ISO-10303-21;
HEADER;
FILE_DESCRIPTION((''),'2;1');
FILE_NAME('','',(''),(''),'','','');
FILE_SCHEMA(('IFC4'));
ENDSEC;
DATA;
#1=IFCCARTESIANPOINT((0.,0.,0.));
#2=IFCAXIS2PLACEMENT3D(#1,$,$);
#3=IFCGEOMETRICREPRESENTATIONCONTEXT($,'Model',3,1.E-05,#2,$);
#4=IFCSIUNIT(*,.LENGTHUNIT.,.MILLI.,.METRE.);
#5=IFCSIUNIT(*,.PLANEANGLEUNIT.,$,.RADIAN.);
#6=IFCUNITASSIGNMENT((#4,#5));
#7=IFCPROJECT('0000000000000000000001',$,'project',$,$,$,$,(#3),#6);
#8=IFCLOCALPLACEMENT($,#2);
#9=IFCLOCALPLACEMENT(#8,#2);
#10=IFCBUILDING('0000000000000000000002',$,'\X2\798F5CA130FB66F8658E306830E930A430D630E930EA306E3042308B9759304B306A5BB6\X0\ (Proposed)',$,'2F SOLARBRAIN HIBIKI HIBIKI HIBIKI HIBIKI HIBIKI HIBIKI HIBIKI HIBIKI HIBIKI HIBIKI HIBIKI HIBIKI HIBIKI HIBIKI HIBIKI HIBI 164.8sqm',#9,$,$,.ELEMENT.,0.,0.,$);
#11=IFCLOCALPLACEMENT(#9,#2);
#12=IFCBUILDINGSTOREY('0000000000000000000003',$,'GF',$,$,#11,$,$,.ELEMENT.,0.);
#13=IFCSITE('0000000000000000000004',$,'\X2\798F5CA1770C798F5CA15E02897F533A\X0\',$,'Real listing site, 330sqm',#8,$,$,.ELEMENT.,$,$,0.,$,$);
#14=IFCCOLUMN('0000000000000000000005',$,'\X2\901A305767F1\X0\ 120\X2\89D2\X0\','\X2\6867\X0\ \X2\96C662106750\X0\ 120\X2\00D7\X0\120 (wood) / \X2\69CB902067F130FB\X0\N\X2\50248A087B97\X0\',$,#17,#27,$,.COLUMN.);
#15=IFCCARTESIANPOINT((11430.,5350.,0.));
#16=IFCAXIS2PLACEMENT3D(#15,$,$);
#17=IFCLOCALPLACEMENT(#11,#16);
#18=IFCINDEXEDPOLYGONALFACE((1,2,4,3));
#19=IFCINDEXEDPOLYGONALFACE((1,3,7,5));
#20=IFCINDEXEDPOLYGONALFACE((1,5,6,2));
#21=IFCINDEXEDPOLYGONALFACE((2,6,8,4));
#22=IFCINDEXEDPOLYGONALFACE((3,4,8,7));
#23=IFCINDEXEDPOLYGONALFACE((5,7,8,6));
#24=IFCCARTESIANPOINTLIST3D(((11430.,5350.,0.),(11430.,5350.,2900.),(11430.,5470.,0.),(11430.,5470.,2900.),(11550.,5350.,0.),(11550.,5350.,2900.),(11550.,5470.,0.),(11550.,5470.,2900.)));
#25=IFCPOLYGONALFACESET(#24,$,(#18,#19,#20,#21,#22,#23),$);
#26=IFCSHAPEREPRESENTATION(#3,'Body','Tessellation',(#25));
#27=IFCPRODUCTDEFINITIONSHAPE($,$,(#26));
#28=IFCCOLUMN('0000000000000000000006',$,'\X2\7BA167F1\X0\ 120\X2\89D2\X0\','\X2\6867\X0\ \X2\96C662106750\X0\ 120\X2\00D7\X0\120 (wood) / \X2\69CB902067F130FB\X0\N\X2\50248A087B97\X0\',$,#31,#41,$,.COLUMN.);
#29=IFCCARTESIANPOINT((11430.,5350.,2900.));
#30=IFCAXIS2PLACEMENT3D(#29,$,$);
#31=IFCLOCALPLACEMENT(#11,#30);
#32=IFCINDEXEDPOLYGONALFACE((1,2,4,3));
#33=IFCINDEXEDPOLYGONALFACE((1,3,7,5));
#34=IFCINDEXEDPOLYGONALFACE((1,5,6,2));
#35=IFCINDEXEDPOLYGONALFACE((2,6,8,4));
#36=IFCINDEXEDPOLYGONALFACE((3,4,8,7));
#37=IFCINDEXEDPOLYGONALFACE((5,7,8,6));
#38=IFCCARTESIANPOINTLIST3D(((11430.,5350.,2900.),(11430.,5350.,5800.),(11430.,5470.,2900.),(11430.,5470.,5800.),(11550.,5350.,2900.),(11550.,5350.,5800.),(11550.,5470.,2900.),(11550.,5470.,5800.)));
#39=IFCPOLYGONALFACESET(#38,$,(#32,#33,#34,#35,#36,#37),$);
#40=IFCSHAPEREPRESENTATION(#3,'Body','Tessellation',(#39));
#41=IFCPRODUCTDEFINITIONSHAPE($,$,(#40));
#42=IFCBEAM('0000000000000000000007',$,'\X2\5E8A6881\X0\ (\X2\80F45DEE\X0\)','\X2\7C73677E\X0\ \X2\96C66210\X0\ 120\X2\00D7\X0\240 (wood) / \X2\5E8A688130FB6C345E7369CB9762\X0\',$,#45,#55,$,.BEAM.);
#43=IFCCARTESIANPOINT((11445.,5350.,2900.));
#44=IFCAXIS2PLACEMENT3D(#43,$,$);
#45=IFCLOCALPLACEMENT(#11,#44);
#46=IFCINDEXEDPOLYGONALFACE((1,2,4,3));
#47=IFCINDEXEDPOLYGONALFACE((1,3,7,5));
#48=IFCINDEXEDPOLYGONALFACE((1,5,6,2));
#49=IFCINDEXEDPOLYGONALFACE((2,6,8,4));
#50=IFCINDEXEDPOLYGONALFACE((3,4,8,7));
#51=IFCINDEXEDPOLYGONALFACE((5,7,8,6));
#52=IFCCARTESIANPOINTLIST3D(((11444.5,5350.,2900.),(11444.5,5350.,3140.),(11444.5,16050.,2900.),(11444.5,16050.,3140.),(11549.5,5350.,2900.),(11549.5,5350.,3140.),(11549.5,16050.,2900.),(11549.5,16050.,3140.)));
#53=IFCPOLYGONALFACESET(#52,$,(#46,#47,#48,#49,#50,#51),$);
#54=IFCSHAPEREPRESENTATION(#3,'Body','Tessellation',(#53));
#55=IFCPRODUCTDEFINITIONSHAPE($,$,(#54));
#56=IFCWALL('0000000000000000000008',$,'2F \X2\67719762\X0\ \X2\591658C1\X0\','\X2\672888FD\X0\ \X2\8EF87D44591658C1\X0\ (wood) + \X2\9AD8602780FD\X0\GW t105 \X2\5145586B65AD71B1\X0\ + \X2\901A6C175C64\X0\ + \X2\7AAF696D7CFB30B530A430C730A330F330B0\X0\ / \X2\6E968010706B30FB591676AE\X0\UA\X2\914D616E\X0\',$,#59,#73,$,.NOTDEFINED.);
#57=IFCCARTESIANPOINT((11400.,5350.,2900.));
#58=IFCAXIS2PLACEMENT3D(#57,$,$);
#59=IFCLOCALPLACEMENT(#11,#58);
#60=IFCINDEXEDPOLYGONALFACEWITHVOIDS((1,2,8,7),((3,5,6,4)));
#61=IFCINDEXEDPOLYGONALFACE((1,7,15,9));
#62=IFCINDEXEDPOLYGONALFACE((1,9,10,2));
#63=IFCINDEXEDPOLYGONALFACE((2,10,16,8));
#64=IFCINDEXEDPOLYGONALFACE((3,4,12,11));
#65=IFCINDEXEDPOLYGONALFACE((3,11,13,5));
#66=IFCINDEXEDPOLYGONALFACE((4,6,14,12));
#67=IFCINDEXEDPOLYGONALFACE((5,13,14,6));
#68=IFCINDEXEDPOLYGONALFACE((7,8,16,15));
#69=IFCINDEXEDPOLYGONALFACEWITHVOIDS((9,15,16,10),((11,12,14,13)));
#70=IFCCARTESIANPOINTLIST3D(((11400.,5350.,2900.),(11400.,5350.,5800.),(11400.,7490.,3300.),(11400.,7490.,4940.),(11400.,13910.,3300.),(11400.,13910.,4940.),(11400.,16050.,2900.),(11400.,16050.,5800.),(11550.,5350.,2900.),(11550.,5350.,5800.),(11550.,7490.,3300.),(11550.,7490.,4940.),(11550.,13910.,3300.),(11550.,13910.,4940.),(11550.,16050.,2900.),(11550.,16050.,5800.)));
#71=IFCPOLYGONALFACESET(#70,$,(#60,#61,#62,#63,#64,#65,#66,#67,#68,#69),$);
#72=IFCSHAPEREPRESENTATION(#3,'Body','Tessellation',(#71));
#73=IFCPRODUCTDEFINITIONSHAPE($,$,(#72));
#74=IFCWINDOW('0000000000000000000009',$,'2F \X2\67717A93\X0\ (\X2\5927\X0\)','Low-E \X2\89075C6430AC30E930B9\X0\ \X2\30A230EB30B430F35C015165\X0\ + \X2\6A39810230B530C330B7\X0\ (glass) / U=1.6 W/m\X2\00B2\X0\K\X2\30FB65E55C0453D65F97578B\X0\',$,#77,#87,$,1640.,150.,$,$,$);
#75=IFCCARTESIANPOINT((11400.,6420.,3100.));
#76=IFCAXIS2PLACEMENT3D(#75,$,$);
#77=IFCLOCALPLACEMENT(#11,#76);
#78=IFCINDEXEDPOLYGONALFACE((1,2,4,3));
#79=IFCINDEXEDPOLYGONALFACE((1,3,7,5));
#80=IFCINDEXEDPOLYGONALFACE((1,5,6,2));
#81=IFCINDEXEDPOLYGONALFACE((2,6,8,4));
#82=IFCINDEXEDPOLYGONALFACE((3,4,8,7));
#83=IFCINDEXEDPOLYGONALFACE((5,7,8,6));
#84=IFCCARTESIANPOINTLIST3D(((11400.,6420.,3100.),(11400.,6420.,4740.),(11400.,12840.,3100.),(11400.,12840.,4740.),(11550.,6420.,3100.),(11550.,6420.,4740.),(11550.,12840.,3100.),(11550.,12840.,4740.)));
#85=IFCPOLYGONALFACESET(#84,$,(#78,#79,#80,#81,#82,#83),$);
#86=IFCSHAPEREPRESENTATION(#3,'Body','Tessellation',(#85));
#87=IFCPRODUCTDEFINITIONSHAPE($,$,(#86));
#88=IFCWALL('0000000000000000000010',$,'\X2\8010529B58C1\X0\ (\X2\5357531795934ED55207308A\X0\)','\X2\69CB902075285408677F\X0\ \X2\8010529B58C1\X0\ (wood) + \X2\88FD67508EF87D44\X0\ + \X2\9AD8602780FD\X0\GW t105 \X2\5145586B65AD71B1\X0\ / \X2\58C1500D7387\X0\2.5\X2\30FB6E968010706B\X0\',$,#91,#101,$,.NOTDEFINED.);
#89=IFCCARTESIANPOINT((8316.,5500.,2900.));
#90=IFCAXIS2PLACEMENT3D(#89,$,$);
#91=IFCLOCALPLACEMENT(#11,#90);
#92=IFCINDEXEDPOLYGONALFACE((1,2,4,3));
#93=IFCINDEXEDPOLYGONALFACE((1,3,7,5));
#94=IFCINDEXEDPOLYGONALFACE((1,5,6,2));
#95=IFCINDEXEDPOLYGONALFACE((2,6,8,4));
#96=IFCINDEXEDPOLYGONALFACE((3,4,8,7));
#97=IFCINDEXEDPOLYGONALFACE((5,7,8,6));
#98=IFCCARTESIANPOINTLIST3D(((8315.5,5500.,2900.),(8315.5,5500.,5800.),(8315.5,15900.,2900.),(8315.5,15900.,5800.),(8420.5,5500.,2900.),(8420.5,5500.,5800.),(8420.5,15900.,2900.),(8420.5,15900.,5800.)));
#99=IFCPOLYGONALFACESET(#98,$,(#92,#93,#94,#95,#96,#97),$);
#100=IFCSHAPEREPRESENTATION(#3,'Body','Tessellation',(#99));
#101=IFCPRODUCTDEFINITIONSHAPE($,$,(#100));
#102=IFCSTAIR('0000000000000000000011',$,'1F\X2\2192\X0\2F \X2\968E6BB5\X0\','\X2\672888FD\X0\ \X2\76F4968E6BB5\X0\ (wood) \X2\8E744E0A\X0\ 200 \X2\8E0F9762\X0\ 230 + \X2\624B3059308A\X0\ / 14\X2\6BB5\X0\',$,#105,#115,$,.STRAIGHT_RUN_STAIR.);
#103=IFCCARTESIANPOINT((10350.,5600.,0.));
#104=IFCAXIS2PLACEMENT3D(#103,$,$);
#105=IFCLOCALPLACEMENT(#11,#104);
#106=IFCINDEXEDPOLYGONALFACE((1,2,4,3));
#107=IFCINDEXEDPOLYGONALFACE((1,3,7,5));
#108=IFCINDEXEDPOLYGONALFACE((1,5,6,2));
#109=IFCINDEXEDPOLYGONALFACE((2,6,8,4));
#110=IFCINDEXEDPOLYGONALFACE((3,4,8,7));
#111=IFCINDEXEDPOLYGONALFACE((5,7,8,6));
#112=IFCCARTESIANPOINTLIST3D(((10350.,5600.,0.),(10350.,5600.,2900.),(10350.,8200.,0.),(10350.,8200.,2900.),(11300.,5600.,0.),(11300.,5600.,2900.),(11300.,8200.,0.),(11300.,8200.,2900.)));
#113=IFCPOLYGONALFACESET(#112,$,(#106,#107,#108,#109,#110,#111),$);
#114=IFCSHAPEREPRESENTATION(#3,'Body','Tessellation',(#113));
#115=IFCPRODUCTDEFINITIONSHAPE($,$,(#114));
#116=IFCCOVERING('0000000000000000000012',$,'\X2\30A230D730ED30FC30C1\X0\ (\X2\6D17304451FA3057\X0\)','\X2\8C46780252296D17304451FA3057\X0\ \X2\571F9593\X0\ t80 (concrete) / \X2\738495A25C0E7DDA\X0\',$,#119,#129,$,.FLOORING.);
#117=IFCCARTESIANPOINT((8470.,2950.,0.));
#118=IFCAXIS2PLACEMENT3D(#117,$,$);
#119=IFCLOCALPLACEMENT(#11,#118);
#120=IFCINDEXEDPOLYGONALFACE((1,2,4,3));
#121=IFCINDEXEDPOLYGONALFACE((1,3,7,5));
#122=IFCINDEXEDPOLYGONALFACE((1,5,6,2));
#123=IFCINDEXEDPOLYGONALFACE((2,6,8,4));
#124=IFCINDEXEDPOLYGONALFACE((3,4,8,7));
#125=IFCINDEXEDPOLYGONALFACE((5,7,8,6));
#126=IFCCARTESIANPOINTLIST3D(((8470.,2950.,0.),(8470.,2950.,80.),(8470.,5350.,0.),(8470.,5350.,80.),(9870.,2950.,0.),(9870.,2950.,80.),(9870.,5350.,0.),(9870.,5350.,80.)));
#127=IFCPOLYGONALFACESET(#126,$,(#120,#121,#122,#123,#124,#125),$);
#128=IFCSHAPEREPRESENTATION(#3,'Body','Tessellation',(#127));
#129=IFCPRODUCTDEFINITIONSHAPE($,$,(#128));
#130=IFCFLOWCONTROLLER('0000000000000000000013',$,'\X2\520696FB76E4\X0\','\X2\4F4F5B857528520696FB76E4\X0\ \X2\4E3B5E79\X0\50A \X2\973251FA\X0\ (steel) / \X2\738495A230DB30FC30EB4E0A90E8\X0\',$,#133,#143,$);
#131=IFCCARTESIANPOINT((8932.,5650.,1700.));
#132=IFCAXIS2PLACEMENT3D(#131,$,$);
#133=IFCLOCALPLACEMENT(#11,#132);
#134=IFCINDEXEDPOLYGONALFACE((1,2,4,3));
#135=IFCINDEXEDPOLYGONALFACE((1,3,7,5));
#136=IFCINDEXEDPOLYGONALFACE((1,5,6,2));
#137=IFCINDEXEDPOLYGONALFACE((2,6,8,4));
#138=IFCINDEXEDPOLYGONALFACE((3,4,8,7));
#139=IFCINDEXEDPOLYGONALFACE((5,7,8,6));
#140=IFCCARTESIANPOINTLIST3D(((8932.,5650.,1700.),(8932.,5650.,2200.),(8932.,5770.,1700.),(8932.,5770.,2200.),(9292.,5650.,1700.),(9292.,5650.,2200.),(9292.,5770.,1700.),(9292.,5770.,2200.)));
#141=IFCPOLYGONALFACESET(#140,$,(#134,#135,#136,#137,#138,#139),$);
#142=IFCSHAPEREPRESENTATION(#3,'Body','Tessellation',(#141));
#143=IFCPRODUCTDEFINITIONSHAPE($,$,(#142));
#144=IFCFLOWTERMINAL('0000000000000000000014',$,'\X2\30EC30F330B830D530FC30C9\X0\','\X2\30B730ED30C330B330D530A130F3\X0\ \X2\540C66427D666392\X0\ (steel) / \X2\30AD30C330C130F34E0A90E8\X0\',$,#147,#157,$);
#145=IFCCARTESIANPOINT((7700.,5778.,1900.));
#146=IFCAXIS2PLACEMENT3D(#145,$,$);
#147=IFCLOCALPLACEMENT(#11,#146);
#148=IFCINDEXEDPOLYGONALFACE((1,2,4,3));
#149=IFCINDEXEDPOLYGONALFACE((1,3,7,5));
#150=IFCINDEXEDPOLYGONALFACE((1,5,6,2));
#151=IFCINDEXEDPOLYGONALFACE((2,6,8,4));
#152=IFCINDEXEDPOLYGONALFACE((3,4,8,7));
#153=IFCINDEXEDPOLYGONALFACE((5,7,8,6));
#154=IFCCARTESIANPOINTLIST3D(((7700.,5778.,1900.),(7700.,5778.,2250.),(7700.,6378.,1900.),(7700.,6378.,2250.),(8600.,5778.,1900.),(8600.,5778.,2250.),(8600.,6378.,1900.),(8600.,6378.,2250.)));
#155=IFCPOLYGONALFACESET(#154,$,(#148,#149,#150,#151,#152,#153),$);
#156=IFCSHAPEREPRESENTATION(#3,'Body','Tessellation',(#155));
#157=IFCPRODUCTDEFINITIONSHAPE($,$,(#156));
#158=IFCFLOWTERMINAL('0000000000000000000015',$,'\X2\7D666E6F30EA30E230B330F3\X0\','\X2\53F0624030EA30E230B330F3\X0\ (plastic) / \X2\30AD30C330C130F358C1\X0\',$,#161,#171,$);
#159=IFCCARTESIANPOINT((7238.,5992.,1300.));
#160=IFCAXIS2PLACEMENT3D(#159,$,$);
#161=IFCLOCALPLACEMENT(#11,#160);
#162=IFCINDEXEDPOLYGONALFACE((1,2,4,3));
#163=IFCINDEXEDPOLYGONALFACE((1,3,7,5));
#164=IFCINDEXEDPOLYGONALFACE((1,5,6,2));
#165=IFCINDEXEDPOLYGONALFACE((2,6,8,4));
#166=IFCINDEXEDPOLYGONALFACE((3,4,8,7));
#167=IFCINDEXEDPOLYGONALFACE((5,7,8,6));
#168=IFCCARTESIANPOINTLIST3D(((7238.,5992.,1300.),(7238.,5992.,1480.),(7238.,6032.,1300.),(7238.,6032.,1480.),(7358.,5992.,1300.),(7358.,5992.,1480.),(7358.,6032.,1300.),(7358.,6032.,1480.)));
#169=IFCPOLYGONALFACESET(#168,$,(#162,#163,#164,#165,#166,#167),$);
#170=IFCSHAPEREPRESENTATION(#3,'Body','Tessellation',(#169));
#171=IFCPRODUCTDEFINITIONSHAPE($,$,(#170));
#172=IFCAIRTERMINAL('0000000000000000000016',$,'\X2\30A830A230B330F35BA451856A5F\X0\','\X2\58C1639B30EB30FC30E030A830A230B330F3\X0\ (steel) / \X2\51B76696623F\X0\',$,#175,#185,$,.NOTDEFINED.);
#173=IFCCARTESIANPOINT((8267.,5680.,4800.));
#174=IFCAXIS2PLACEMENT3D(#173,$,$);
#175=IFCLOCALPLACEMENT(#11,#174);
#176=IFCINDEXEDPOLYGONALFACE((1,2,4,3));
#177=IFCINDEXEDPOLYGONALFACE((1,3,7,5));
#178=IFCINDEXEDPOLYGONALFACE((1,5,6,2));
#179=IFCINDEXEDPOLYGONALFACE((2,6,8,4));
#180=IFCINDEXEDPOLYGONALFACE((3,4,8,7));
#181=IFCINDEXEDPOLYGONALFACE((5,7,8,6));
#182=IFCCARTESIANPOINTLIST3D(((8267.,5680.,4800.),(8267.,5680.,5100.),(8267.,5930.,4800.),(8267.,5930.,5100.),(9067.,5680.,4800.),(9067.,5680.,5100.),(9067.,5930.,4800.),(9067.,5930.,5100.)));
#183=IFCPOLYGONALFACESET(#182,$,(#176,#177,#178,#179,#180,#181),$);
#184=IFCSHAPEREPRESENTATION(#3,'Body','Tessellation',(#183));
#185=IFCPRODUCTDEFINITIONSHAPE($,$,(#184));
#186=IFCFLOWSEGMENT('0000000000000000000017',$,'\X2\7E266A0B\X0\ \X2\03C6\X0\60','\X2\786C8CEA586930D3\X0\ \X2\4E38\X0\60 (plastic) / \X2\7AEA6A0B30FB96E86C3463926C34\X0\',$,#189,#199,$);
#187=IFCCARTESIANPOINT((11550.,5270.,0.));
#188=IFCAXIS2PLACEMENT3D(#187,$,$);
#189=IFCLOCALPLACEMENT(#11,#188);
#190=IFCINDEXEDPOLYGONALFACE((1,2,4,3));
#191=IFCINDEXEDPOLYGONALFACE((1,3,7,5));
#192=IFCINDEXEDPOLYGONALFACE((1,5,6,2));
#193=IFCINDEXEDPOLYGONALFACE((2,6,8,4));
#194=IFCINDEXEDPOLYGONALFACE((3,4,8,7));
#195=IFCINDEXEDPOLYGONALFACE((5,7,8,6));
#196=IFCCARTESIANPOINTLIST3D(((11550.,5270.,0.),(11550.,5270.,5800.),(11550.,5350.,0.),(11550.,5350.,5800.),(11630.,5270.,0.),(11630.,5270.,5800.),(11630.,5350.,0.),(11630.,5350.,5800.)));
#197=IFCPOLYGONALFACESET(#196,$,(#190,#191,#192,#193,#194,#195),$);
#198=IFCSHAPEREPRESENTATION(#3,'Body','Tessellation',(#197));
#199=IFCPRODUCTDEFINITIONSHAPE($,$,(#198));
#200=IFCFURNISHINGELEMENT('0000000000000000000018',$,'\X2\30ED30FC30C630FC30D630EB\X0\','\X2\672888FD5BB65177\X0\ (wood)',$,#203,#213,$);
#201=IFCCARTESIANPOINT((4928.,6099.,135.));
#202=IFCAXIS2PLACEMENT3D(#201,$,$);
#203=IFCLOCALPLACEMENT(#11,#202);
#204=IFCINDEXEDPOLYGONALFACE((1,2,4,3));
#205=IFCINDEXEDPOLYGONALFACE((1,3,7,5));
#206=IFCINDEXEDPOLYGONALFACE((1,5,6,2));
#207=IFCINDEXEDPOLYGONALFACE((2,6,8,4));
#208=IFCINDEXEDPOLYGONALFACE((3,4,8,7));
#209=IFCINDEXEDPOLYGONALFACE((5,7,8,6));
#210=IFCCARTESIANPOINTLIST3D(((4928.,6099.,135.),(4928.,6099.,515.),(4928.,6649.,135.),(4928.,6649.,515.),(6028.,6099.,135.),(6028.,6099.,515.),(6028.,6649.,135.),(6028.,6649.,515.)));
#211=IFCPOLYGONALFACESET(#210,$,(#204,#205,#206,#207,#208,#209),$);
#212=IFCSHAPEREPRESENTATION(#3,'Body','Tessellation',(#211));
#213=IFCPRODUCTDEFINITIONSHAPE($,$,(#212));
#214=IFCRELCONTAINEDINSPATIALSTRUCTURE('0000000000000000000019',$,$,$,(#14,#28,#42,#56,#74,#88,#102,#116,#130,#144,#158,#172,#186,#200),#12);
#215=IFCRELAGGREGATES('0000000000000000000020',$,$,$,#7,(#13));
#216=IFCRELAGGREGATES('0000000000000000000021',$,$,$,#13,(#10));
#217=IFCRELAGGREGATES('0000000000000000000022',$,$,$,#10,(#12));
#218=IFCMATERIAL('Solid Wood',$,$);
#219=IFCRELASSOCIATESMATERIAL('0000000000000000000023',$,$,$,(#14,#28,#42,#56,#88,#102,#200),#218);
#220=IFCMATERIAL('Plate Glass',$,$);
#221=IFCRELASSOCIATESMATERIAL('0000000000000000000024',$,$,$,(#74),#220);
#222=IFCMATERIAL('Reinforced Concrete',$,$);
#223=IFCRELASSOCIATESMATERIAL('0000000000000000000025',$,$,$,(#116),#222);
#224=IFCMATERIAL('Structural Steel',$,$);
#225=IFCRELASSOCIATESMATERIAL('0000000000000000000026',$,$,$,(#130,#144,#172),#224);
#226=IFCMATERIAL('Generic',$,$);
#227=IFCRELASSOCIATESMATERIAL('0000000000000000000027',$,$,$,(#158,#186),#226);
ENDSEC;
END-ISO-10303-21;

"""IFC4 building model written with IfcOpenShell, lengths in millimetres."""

from ifc_helpers import new_model, si_unit, frame, frame_2d, origin, place, context, project, spatial, rectangle, extrude, material, element, fill, save


model = new_model("IFC4")

# Units and contexts
model_context = context("Model", 3, precision=1e-05, world=origin())
ifc_project = project(units=[si_unit("LENGTHUNIT", "METRE", prefix="MILLI"), si_unit("PLANEANGLEUNIT", "RADIAN")], contexts=[model_context])

# Site, building, storey
site_placement = place(None, origin())
site = spatial("IfcSite", under=ifc_project, at=site_placement, Name="福岡県福岡市西区", ObjectType="Real listing site, 330sqm", CompositionType="ELEMENT", RefElevation=0.0)
building_placement = place(site_placement, origin())
building = spatial("IfcBuilding", under=site, at=building_placement, Name="福岡・書斎とライブラリのある静かな家 (Proposed)", ObjectType="2F SOLARBRAIN HIBIKI HIBIKI HIBIKI HIBIKI HIBIKI HIBIKI HIBIKI HIBIKI HIBIKI HIBIKI HIBIKI HIBIKI HIBIKI HIBIKI HIBIKI HIBI 164.8sqm", CompositionType="ELEMENT", ElevationOfRefHeight=0.0, ElevationOfTerrain=0.0)
storey_placement = place(building_placement, origin())
storey = spatial("IfcBuildingStorey", under=building, at=storey_placement, Name="GF", CompositionType="ELEMENT", Elevation=0.0)

# Columns
ifc_material_1 = material(Name="Solid Wood")
column_1_placement = place(storey_placement, frame((11430.0, 5350.0, 0.0)))
element("IfcColumn", 1, at=column_1_placement, inside=storey, material=ifc_material_1, Name="通し柱 120角", Description="桧 集成材 120×120 (wood) / 構造柱・N値計算", PredefinedType="COLUMN", context=model_context, shape_type="SweptSolid", body=[
    extrude(rectangle(XDim=120.0, YDim=120.0, at=frame_2d((60.0, 60.0))), frame((11430.0, 5350.0, 0.0)), (0.0, 0.0, 1.0), 2900.0),
])
column_2_placement = place(storey_placement, frame((11430.0, 5350.0, 2900.0)))
element("IfcColumn", 2, at=column_2_placement, inside=storey, material=ifc_material_1, Name="管柱 120角", Description="桧 集成材 120×120 (wood) / 構造柱・N値計算", PredefinedType="COLUMN", context=model_context, shape_type="SweptSolid", body=[
    extrude(rectangle(XDim=120.0, YDim=120.0, at=frame_2d((60.0, 60.0))), frame((11430.0, 5350.0, 2900.0)), (0.0, 0.0, 1.0), 2900.0),
])

# Beam
beam_1_placement = place(storey_placement, frame((11445.0, 5350.0, 2900.0)))
element("IfcBeam", 3, at=beam_1_placement, inside=storey, material=ifc_material_1, Name="床梁 (胴差)", Description="米松 集成 120×240 (wood) / 床梁・水平構面", PredefinedType="BEAM", context=model_context, shape_type="SweptSolid", body=[
    extrude(rectangle(XDim=105.0, YDim=10700.0, at=frame_2d((52.0, 5350.0))), frame((11445.0, 5350.0, 2900.0)), (0.0, 0.0, 1.0), 240.0),
])

# Shared definitions
ifc_material_2 = material(Name="Plate Glass")

# Wall, opening, window
wall_1_placement = place(storey_placement, frame((11400.0, 5350.0, 2900.0)))
wall_1 = element("IfcWall", 4, at=wall_1_placement, inside=storey, material=ifc_material_1, Name="2F 東面 外壁", Description="木製 軸組外壁 (wood) + 高性能GW t105 充填断熱 + 通気層 + 窯業系サイディング / 準耐火・外皮UA配慮", PredefinedType="NOTDEFINED", context=model_context, shape_type="SweptSolid", body=[
    extrude(rectangle(XDim=150.0, YDim=10700.0, at=frame_2d((75.0, 5350.0))), frame((11400.0, 5350.0, 2900.0)), (0.0, 0.0, 1.0), 2900.0),
])
opening_1_placement = place(storey_placement, frame((11400.0, 6420.0, 3100.0)))
opening_1 = element("IfcOpeningElement", 5, at=opening_1_placement, cuts=wall_1, PredefinedType="NOTDEFINED", context=model_context, shape_type="SweptSolid", body=[
    extrude(rectangle(XDim=150.0, YDim=6420.0, at=frame_2d((75.0, 3210.0))), frame((11400.0, 6420.0, 3100.0)), (0.0, 0.0, 1.0), 1640.0),
])
window_1_placement = place(storey_placement, frame((11400.0, 6420.0, 3100.0)))
window_1 = element("IfcWindow", 6, at=window_1_placement, inside=storey, material=ifc_material_2, Name="2F 東窓 (大)", Description="Low-E 複層ガラス アルゴン封入 + 樹脂サッシ (glass) / U=1.6 W/m²K・日射取得型", OverallHeight=1640.0, OverallWidth=150.0, context=model_context, shape_type="SweptSolid", body=[
    extrude(rectangle(XDim=150.0, YDim=6420.0, at=frame_2d((75.0, 3210.0))), frame((11400.0, 6420.0, 3100.0)), (0.0, 0.0, 1.0), 1640.0),
])
fill(opening_1, window_1)

# Wall
wall_2_placement = place(storey_placement, frame((8316.0, 5500.0, 2900.0)))
element("IfcWall", 7, at=wall_2_placement, inside=storey, material=ifc_material_1, Name="耐力壁 (南北間仕切り)", Description="構造用合板 耐力壁 (wood) + 製材軸組 + 高性能GW t105 充填断熱 / 壁倍率2.5・準耐火", PredefinedType="NOTDEFINED", context=model_context, shape_type="SweptSolid", body=[
    extrude(rectangle(XDim=105.0, YDim=10400.0, at=frame_2d((52.0, 5200.0))), frame((8316.0, 5500.0, 2900.0)), (0.0, 0.0, 1.0), 2900.0),
])

# Stair
stair_placement = place(storey_placement, frame((10350.0, 5600.0, 0.0)))
element("IfcStair", 8, at=stair_placement, inside=storey, material=ifc_material_1, Name="1F→2F 階段", Description="木製 直階段 (wood) 蹴上 200 踏面 230 + 手すり / 14段", PredefinedType="STRAIGHT_RUN_STAIR", context=model_context, shape_type="SweptSolid", body=[
    extrude(rectangle(XDim=950.0, YDim=2600.0, at=frame_2d((475.0, 1300.0))), frame((10350.0, 5600.0, 0.0)), (0.0, 0.0, 1.0), 2900.0),
])

# Covering
ifc_material_3 = material(Name="Reinforced Concrete")
covering_placement = place(storey_placement, frame((8470.0, 2950.0, 0.0)))
element("IfcCovering", 9, at=covering_placement, inside=storey, material=ifc_material_3, Name="アプローチ (洗い出し)", Description="豆砂利洗い出し 土間 t80 (concrete) / 玄関導線", PredefinedType="FLOORING", context=model_context, shape_type="SweptSolid", body=[
    extrude(rectangle(XDim=1400.0, YDim=2400.0, at=frame_2d((700.0, 1200.0))), frame((8470.0, 2950.0, 0.0)), (0.0, 0.0, 1.0), 80.0),
])

# Flow controller
ifc_material_4 = material(Name="Structural Steel")
flow_controller_placement = place(storey_placement, frame((8932.0, 5650.0, 1700.0)))
element("IfcFlowController", 10, at=flow_controller_placement, inside=storey, material=ifc_material_4, Name="分電盤", Description="住宅用分電盤 主幹50A 露出 (steel) / 玄関ホール上部", context=model_context, shape_type="SweptSolid", body=[
    extrude(rectangle(XDim=360.0, YDim=120.0, at=frame_2d((180.0, 60.0))), frame((8932.0, 5650.0, 1700.0)), (0.0, 0.0, 1.0), 500.0),
])

# Flow terminals
flow_terminal_1_placement = place(storey_placement, frame((7700.0, 5778.0, 1900.0)))
element("IfcFlowTerminal", 11, at=flow_terminal_1_placement, inside=storey, material=ifc_material_4, Name="レンジフード", Description="シロッコファン 同時給排 (steel) / キッチン上部", context=model_context, shape_type="SweptSolid", body=[
    extrude(rectangle(XDim=900.0, YDim=600.0, at=frame_2d((450.0, 300.0))), frame((7700.0, 5778.0, 1900.0)), (0.0, 0.0, 1.0), 350.0),
])
ifc_material_5 = material(Name="Generic")
flow_terminal_2_placement = place(storey_placement, frame((7238.0, 5992.0, 1300.0)))
element("IfcFlowTerminal", 12, at=flow_terminal_2_placement, inside=storey, material=ifc_material_5, Name="給湯リモコン", Description="台所リモコン (plastic) / キッチン壁", context=model_context, shape_type="SweptSolid", body=[
    extrude(rectangle(XDim=120.0, YDim=40.0, at=frame_2d((60.0, 20.0))), frame((7238.0, 5992.0, 1300.0)), (0.0, 0.0, 1.0), 180.0),
])

# Air terminal
air_terminal_placement = place(storey_placement, frame((8267.0, 5680.0, 4800.0)))
element("IfcAirTerminal", 13, at=air_terminal_placement, inside=storey, material=ifc_material_4, Name="エアコン室内機", Description="壁掛ルームエアコン (steel) / 冷暖房", PredefinedType="NOTDEFINED", context=model_context, shape_type="SweptSolid", body=[
    extrude(rectangle(XDim=800.0, YDim=250.0, at=frame_2d((400.0, 125.0))), frame((8267.0, 5680.0, 4800.0)), (0.0, 0.0, 1.0), 300.0),
])

# Flow segment
flow_segment_placement = place(storey_placement, frame((11550.0, 5270.0, 0.0)))
element("IfcFlowSegment", 14, at=flow_segment_placement, inside=storey, material=ifc_material_5, Name="縦樋 φ60", Description="硬質塩ビ 丸60 (plastic) / 竪樋・雨水排水", context=model_context, shape_type="SweptSolid", body=[
    extrude(rectangle(XDim=80.0, YDim=80.0, at=frame_2d((40.0, 40.0))), frame((11550.0, 5270.0, 0.0)), (0.0, 0.0, 1.0), 5800.0),
])

# Furnishing element
furnishing_1_placement = place(storey_placement, frame((4928.0, 6099.0, 135.0)))
element("IfcFurnishingElement", 15, at=furnishing_1_placement, inside=storey, material=ifc_material_1, Name="ローテーブル", Description="木製家具 (wood)", context=model_context, shape_type="SweptSolid", body=[
    extrude(rectangle(XDim=1100.0, YDim=550.0, at=frame_2d((550.0, 275.0))), frame((4928.0, 6099.0, 135.0)), (0.0, 0.0, 1.0), 380.0),
])

save(model, "model.ifc")
